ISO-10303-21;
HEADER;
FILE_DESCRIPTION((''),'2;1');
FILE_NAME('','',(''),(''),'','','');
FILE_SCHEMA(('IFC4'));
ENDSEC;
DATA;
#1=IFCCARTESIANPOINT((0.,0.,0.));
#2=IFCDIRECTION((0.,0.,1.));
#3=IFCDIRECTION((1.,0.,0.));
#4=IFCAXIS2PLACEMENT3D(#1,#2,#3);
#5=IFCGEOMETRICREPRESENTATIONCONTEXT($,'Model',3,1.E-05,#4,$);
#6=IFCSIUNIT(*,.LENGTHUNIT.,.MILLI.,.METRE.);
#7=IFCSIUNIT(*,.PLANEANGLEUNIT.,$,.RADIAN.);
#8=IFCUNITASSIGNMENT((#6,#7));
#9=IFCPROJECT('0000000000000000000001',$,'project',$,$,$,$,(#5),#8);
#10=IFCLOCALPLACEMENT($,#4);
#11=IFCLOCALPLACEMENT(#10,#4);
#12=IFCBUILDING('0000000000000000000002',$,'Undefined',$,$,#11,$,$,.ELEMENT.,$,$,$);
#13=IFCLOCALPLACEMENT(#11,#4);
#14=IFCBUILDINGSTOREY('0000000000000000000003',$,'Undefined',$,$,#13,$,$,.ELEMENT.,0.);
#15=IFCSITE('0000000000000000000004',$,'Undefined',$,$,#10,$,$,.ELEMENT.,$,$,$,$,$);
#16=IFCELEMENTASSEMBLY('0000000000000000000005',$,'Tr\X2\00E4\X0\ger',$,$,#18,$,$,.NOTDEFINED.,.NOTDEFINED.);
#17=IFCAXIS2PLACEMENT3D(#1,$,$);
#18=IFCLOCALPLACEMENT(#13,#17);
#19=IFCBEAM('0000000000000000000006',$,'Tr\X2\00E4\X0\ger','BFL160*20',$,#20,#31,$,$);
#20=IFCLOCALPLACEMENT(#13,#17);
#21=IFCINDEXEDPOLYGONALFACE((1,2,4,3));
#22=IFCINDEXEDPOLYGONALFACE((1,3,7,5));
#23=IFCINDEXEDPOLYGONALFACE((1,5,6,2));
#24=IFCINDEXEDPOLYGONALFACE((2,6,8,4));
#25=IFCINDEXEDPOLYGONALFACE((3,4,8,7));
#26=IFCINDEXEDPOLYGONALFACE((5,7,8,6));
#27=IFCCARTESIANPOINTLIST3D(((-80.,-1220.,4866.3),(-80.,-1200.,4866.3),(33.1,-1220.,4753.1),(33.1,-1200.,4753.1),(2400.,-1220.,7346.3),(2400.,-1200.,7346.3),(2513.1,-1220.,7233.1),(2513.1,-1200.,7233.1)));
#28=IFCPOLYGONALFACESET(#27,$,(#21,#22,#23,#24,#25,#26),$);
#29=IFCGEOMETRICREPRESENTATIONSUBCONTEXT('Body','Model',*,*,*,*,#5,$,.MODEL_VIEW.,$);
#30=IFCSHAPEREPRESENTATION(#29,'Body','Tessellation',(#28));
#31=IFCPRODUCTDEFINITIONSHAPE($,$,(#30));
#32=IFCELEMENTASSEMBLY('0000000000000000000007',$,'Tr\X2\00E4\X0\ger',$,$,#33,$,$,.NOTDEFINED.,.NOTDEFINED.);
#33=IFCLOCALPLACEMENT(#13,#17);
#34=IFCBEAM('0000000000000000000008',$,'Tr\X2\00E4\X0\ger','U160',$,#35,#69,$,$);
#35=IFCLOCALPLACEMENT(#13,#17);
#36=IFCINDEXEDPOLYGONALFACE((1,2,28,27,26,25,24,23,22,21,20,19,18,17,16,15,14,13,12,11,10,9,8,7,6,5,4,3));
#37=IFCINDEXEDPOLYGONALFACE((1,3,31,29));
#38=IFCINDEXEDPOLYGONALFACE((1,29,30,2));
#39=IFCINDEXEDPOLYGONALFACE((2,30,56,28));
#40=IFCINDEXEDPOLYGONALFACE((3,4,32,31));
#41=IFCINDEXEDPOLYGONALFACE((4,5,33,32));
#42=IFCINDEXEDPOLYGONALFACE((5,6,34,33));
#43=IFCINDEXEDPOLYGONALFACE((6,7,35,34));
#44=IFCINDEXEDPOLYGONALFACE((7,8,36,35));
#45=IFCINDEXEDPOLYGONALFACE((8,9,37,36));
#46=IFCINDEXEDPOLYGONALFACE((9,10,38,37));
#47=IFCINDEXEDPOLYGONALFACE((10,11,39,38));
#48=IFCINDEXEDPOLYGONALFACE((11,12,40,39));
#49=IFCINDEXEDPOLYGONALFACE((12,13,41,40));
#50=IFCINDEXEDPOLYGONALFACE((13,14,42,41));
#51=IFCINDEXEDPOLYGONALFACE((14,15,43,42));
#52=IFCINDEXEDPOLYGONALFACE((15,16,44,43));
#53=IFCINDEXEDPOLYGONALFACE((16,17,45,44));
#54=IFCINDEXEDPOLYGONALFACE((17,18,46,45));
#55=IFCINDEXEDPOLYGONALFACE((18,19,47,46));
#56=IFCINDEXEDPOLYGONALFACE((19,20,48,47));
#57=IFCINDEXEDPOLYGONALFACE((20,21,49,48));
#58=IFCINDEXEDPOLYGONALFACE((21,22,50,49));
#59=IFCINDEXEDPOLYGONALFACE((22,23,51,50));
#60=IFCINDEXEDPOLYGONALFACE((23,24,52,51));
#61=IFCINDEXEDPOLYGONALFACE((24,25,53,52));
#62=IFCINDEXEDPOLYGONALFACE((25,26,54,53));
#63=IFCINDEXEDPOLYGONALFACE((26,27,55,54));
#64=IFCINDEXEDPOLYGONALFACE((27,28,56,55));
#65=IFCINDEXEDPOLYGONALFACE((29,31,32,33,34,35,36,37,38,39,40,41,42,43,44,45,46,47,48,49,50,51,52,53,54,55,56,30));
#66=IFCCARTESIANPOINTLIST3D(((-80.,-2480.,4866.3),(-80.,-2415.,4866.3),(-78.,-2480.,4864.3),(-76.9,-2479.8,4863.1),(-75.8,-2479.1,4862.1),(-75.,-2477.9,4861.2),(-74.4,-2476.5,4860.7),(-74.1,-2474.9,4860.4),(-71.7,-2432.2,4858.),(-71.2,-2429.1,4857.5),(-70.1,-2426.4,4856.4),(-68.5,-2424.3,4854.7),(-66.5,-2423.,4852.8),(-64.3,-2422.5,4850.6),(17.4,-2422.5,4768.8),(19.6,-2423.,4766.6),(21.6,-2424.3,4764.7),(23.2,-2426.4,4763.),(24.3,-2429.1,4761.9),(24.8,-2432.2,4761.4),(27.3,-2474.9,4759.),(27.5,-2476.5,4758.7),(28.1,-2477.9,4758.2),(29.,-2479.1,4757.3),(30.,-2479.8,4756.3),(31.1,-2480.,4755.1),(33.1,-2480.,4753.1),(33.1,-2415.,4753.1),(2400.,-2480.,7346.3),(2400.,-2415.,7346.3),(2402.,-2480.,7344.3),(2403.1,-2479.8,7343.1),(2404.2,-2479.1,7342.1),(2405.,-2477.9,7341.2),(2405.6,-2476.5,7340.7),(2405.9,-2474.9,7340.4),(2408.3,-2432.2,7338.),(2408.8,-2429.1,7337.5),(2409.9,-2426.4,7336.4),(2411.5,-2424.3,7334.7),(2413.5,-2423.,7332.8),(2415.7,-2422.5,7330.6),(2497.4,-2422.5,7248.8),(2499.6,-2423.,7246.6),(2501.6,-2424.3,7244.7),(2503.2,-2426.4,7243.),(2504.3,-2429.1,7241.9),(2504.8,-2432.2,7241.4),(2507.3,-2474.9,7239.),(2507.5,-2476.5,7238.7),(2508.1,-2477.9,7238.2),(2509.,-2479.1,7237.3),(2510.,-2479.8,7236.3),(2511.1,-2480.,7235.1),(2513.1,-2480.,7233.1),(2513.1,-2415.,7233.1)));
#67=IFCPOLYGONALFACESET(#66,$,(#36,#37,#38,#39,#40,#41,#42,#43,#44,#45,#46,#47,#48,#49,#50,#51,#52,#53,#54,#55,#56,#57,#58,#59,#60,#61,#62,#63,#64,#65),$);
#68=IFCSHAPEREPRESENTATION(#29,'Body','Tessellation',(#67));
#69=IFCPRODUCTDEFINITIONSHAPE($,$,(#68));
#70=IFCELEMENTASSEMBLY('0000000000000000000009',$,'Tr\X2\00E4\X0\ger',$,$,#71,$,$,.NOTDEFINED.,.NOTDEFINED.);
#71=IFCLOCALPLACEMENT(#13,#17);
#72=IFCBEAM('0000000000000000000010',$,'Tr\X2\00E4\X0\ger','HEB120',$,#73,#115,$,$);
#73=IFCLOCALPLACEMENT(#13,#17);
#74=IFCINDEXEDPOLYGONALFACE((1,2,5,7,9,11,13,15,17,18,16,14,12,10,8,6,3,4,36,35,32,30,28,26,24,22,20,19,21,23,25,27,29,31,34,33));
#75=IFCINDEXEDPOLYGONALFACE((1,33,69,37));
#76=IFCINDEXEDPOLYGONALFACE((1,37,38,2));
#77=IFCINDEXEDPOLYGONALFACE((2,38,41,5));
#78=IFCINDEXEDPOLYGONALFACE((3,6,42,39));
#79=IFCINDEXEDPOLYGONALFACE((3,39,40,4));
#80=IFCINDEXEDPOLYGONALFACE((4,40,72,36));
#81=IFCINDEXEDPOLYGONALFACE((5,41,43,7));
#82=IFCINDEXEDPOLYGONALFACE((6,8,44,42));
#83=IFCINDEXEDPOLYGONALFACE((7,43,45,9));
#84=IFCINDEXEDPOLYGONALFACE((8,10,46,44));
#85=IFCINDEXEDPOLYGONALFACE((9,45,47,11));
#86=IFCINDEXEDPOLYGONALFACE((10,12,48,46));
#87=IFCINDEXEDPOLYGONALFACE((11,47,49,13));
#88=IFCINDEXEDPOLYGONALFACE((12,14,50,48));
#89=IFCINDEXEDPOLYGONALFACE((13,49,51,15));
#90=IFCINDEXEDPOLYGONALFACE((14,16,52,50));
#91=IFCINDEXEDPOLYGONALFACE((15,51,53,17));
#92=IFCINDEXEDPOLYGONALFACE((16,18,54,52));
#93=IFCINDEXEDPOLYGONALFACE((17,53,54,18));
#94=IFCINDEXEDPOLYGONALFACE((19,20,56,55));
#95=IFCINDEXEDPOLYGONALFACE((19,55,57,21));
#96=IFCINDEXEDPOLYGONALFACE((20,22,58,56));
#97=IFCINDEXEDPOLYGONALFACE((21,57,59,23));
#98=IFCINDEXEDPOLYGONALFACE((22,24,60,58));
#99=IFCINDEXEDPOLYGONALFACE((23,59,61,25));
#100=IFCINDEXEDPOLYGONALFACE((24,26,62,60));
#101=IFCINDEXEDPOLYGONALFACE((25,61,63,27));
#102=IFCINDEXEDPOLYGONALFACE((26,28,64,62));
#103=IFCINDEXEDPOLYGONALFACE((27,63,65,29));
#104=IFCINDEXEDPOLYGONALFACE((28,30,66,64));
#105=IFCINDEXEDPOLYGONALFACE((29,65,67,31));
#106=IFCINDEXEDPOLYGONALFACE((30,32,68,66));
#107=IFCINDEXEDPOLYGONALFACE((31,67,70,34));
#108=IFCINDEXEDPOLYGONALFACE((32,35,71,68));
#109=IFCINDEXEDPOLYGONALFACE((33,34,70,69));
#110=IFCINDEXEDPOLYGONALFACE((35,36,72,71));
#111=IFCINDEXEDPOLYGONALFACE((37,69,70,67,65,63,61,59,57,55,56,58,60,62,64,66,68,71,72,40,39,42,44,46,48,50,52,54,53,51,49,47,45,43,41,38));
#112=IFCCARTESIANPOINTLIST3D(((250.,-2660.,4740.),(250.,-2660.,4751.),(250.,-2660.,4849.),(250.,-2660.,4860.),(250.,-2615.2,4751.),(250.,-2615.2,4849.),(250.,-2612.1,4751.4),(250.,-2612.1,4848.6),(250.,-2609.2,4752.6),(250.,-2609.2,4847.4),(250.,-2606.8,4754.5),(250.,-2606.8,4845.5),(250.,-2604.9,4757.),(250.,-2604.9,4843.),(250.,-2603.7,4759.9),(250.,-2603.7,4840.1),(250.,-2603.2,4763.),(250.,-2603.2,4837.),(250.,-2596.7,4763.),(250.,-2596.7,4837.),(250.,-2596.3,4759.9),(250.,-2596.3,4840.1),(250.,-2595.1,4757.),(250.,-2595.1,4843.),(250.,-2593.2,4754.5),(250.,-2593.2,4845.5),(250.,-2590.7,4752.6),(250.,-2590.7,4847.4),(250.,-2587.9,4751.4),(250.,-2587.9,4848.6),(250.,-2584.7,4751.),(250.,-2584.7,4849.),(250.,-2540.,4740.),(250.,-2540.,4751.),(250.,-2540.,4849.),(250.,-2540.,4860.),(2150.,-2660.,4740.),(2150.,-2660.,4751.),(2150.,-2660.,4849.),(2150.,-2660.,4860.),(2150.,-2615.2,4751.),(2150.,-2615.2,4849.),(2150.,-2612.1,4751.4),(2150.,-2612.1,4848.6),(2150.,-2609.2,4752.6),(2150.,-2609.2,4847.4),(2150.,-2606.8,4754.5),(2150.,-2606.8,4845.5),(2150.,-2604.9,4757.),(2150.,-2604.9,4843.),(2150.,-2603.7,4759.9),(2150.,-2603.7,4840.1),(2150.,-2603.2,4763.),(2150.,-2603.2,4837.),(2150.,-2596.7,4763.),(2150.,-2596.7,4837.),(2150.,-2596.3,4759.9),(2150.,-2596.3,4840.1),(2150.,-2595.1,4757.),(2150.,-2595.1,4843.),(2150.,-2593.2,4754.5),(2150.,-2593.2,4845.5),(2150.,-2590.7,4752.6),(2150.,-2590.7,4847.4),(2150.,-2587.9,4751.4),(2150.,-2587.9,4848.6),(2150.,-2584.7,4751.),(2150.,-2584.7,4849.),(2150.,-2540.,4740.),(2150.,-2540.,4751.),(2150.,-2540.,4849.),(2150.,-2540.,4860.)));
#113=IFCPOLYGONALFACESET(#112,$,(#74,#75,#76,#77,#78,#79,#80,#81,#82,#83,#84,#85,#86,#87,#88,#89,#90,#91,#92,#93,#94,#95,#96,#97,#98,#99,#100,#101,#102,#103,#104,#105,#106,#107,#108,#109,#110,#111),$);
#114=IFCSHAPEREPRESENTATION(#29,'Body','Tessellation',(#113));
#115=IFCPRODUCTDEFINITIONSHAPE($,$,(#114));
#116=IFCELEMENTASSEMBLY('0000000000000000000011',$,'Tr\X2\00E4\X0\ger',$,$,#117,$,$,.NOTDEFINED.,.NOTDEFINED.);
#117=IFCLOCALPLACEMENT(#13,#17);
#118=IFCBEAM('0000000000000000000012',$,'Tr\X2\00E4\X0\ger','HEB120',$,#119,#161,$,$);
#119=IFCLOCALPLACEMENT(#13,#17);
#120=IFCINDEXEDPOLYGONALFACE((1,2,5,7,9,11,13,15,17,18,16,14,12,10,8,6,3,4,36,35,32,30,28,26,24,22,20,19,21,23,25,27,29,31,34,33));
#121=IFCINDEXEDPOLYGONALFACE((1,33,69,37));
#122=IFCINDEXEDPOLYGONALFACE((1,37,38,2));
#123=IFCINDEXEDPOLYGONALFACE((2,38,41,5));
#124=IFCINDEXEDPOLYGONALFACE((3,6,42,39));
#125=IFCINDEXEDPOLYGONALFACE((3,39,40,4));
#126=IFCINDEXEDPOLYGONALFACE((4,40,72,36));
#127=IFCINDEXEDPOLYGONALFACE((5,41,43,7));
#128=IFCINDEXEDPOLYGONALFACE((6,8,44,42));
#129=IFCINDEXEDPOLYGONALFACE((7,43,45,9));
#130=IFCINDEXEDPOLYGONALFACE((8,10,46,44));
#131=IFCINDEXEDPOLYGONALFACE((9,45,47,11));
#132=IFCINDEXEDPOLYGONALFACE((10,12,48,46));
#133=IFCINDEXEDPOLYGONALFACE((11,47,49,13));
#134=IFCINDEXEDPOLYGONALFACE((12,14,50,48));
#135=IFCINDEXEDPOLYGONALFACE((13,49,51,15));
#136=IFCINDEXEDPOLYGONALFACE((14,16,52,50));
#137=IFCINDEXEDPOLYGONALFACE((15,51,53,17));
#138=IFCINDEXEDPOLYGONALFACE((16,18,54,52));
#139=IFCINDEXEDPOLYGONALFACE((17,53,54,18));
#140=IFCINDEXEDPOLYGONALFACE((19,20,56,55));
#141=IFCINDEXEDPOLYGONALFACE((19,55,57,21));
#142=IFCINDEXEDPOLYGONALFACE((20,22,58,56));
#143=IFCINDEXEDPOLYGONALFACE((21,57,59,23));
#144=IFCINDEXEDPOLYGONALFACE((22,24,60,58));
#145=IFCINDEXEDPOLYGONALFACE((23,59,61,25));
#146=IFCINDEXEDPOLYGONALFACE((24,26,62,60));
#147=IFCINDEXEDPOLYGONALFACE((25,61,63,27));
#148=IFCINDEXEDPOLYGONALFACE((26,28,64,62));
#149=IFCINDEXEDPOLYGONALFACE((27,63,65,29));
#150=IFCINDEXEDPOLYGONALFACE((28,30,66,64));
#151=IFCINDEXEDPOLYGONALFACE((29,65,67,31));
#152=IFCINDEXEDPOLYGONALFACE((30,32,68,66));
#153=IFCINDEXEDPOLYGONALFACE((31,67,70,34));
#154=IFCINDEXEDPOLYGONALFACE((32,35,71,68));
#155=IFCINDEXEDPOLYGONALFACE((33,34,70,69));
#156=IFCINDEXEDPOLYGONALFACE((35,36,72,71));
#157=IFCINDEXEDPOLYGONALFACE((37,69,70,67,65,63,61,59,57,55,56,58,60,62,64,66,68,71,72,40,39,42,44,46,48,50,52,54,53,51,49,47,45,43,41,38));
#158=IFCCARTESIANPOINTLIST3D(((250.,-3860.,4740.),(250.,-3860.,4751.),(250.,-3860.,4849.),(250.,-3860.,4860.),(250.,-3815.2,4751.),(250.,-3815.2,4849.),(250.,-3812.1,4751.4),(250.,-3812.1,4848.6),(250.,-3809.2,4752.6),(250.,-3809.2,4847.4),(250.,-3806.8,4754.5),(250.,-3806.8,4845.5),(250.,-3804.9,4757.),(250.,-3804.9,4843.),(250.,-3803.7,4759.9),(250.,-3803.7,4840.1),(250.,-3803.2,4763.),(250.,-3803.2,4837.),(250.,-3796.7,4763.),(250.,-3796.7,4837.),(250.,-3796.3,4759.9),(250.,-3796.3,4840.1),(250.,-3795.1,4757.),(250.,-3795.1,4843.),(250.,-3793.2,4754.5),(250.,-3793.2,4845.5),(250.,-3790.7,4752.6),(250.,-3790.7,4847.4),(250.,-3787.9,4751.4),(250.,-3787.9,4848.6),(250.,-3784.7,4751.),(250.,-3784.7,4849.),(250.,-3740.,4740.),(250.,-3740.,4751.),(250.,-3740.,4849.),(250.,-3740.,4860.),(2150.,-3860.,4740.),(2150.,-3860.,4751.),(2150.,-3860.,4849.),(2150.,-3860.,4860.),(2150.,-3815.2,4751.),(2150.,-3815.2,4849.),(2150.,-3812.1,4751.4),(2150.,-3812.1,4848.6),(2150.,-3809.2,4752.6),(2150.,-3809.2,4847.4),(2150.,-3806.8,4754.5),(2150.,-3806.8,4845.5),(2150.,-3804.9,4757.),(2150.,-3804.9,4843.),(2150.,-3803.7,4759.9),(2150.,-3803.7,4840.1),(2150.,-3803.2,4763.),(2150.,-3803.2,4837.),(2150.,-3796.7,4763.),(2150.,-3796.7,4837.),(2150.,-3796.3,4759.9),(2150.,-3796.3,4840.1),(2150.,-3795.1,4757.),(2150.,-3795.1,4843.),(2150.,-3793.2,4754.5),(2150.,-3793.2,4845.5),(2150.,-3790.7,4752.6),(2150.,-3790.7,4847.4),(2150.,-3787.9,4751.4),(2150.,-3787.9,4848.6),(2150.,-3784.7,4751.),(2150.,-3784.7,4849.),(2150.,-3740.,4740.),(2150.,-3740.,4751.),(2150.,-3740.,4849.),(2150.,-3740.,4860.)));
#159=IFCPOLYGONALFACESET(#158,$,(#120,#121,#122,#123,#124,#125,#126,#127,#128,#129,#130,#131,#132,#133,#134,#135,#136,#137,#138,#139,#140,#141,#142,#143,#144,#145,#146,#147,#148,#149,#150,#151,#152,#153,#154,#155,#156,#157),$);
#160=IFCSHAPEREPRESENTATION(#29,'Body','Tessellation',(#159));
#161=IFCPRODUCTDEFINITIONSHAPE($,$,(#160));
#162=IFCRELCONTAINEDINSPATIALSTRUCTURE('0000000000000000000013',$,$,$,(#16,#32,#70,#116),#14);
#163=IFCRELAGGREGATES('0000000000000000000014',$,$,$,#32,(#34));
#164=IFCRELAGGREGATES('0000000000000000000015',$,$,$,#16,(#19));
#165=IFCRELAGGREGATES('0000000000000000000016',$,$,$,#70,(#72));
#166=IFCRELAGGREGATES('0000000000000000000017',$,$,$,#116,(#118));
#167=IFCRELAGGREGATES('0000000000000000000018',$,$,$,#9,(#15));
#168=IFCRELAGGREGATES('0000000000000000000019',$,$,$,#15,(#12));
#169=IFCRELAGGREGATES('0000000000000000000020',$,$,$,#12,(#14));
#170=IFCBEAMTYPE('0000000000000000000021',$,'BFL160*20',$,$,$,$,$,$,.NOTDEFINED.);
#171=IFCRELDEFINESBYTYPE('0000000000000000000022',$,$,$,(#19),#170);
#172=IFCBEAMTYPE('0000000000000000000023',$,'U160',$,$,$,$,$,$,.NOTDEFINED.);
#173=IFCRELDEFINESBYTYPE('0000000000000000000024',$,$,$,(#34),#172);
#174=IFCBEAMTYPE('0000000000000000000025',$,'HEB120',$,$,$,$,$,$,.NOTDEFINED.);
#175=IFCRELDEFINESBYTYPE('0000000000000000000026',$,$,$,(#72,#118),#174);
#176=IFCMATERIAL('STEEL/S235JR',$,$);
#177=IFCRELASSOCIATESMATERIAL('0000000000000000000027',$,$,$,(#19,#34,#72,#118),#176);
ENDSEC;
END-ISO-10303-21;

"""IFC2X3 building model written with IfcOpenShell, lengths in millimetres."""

from ifc_helpers import new_model, si_unit, frame, origin_with_axes, origin_2d_with_axis, place, context, subcontext, project, spatial, rectangle, i_section, u_section, extrude, clip, halfspace, material, type_object, element, aggregate, save


model = new_model("IFC2X3")

# Units and contexts
model_context = context("Model", 3, precision=1e-05, world=origin_with_axes())
body_context = subcontext(model_context, "Body", "Model", "MODEL_VIEW")
ifc_project = project(units=[si_unit("LENGTHUNIT", "METRE", prefix="MILLI"), si_unit("PLANEANGLEUNIT", "RADIAN")], contexts=[model_context])

# Site, building, storey
site_placement = place(None, origin_with_axes())
site = spatial("IfcSite", under=ifc_project, at=site_placement, Name="Undefined", CompositionType="ELEMENT")
building_placement = place(site_placement, origin_with_axes())
building = spatial("IfcBuilding", under=site, at=building_placement, Name="Undefined", CompositionType="ELEMENT")
storey_placement = place(building_placement, origin_with_axes())
storey = spatial("IfcBuildingStorey", under=building, at=storey_placement, Name="Undefined", CompositionType="ELEMENT", Elevation=0.0)

# Element assemblies, beams
assembly_1_placement = place(storey_placement, origin_with_axes())
assembly_1 = element("IfcElementAssembly", 1, at=assembly_1_placement, inside=storey, Name="Träger", AssemblyPlace="NOTDEFINED", PredefinedType="NOTDEFINED")
ifc_material_1 = material(Name="STEEL/S235JR")
beam_type_1 = type_object("IfcBeamType", Name="BFL160*20", PredefinedType="NOTDEFINED")
beam_1_placement = place(assembly_1_placement, frame((-23.4, -1210.0, 4809.7), z_axis=(-0.707107, 0.0, 0.707107), x_axis=(0.707107, 0.0, 0.707107)))
beam_1 = element("IfcBeam", 2, at=beam_1_placement, type_object=beam_type_1, material=ifc_material_1, Name="Träger", Description="BFL160*20", context=body_context, shape_type="SweptSolid", body=[
    extrude(rectangle(XDim=20.0, YDim=160.0, at=origin_2d_with_axis()), frame((3507.2, 0.0, 0.0), z_axis=(-1.0, 0.0, 0.0), x_axis=(0.0, -1.0, 0.0)), (0.0, 0.0, 1.0), 3507.2),
])
assembly_2_placement = place(storey_placement, origin_with_axes())
assembly_2 = element("IfcElementAssembly", 3, at=assembly_2_placement, inside=storey, Name="Träger", AssemblyPlace="NOTDEFINED", PredefinedType="NOTDEFINED")
beam_type_2 = type_object("IfcBeamType", Name="U160", PredefinedType="NOTDEFINED")
beam_2_placement = place(assembly_2_placement, frame((-23.4, -2447.5, 4809.7), z_axis=(-0.707107, 0.0, 0.707107), x_axis=(0.707107, 0.0, 0.707107)))
beam_2 = element("IfcBeam", 4, at=beam_2_placement, type_object=beam_type_2, material=ifc_material_1, Name="Träger", Description="U160", context=body_context, shape_type="SweptSolid", body=[
    extrude(u_section(Depth=160.0, FlangeWidth=65.0, WebThickness=7.5, FlangeThickness=10.5, FilletRadius=10.5, EdgeRadius=5.5, FlangeSlope=0.07983, at=origin_2d_with_axis()), frame((3507.2, 0.0, 0.0), z_axis=(-1.0, 0.0, 0.0), x_axis=(0.0, -1.0, 0.0)), (0.0, 0.0, 1.0), 3507.2),
])
beam_type_3 = type_object("IfcBeamType", Name="HEB120", PredefinedType="NOTDEFINED")
assembly_3_placement = place(storey_placement, origin_with_axes())
assembly_3 = element("IfcElementAssembly", 5, at=assembly_3_placement, inside=storey, Name="Träger", AssemblyPlace="NOTDEFINED", PredefinedType="NOTDEFINED")
beam_3_placement = place(assembly_3_placement, frame((250.0, -2600.0, 4800.0), z_axis=(0.0, 0.0, 1.0), x_axis=(1.0, 0.0, 0.0)))
beam_3 = element("IfcBeam", 6, at=beam_3_placement, type_object=beam_type_3, material=ifc_material_1, Name="Träger", Description="HEB120", context=body_context, shape_type="Clipping", body=[
    clip(clip(extrude(i_section(OverallWidth=120.0, OverallDepth=120.0, WebThickness=6.5, FlangeThickness=11.0, FilletRadius=12.0, at=origin_2d_with_axis()), frame((1910.0, 0.0, 0.0), z_axis=(-1.0, 0.0, 0.0), x_axis=(0.0, -1.0, 0.0)), (0.0, 0.0, 1.0), 1910.0), halfspace(frame((1900.0, 0.0, -60.0), z_axis=(-1.0, 0.0, 0.0), x_axis=(0.0, 1.0, 0.0)), True)), halfspace(frame((0.0, 0.0, -60.0), z_axis=(1.0, 0.0, 0.0), x_axis=(0.0, -1.0, 0.0)), True)),
])
assembly_4_placement = place(storey_placement, origin_with_axes())
assembly_4 = element("IfcElementAssembly", 7, at=assembly_4_placement, inside=storey, Name="Träger", AssemblyPlace="NOTDEFINED", PredefinedType="NOTDEFINED")
beam_4_placement = place(assembly_4_placement, frame((250.0, -3800.0, 4800.0), z_axis=(0.0, 0.0, 1.0), x_axis=(1.0, 0.0, 0.0)))
beam_4 = element("IfcBeam", 8, at=beam_4_placement, type_object=beam_type_3, material=ifc_material_1, Name="Träger", Description="HEB120", context=body_context, shape_type="Clipping", body=[
    clip(clip(extrude(i_section(OverallWidth=120.0, OverallDepth=120.0, WebThickness=6.5, FlangeThickness=11.0, FilletRadius=12.0, at=origin_2d_with_axis()), frame((1910.0, 0.0, 0.0), z_axis=(-1.0, 0.0, 0.0), x_axis=(0.0, -1.0, 0.0)), (0.0, 0.0, 1.0), 1910.0), halfspace(frame((1900.0, 0.0, -60.0), z_axis=(-1.0, 0.0, 0.0), x_axis=(0.0, 1.0, 0.0)), True)), halfspace(frame((0.0, 0.0, -60.0), z_axis=(1.0, 0.0, 0.0), x_axis=(0.0, -1.0, 0.0)), True)),
])

aggregate(assembly_2, [beam_2])
aggregate(assembly_1, [beam_1])
aggregate(assembly_3, [beam_3])
aggregate(assembly_4, [beam_4])

save(model, "model.ifc")
